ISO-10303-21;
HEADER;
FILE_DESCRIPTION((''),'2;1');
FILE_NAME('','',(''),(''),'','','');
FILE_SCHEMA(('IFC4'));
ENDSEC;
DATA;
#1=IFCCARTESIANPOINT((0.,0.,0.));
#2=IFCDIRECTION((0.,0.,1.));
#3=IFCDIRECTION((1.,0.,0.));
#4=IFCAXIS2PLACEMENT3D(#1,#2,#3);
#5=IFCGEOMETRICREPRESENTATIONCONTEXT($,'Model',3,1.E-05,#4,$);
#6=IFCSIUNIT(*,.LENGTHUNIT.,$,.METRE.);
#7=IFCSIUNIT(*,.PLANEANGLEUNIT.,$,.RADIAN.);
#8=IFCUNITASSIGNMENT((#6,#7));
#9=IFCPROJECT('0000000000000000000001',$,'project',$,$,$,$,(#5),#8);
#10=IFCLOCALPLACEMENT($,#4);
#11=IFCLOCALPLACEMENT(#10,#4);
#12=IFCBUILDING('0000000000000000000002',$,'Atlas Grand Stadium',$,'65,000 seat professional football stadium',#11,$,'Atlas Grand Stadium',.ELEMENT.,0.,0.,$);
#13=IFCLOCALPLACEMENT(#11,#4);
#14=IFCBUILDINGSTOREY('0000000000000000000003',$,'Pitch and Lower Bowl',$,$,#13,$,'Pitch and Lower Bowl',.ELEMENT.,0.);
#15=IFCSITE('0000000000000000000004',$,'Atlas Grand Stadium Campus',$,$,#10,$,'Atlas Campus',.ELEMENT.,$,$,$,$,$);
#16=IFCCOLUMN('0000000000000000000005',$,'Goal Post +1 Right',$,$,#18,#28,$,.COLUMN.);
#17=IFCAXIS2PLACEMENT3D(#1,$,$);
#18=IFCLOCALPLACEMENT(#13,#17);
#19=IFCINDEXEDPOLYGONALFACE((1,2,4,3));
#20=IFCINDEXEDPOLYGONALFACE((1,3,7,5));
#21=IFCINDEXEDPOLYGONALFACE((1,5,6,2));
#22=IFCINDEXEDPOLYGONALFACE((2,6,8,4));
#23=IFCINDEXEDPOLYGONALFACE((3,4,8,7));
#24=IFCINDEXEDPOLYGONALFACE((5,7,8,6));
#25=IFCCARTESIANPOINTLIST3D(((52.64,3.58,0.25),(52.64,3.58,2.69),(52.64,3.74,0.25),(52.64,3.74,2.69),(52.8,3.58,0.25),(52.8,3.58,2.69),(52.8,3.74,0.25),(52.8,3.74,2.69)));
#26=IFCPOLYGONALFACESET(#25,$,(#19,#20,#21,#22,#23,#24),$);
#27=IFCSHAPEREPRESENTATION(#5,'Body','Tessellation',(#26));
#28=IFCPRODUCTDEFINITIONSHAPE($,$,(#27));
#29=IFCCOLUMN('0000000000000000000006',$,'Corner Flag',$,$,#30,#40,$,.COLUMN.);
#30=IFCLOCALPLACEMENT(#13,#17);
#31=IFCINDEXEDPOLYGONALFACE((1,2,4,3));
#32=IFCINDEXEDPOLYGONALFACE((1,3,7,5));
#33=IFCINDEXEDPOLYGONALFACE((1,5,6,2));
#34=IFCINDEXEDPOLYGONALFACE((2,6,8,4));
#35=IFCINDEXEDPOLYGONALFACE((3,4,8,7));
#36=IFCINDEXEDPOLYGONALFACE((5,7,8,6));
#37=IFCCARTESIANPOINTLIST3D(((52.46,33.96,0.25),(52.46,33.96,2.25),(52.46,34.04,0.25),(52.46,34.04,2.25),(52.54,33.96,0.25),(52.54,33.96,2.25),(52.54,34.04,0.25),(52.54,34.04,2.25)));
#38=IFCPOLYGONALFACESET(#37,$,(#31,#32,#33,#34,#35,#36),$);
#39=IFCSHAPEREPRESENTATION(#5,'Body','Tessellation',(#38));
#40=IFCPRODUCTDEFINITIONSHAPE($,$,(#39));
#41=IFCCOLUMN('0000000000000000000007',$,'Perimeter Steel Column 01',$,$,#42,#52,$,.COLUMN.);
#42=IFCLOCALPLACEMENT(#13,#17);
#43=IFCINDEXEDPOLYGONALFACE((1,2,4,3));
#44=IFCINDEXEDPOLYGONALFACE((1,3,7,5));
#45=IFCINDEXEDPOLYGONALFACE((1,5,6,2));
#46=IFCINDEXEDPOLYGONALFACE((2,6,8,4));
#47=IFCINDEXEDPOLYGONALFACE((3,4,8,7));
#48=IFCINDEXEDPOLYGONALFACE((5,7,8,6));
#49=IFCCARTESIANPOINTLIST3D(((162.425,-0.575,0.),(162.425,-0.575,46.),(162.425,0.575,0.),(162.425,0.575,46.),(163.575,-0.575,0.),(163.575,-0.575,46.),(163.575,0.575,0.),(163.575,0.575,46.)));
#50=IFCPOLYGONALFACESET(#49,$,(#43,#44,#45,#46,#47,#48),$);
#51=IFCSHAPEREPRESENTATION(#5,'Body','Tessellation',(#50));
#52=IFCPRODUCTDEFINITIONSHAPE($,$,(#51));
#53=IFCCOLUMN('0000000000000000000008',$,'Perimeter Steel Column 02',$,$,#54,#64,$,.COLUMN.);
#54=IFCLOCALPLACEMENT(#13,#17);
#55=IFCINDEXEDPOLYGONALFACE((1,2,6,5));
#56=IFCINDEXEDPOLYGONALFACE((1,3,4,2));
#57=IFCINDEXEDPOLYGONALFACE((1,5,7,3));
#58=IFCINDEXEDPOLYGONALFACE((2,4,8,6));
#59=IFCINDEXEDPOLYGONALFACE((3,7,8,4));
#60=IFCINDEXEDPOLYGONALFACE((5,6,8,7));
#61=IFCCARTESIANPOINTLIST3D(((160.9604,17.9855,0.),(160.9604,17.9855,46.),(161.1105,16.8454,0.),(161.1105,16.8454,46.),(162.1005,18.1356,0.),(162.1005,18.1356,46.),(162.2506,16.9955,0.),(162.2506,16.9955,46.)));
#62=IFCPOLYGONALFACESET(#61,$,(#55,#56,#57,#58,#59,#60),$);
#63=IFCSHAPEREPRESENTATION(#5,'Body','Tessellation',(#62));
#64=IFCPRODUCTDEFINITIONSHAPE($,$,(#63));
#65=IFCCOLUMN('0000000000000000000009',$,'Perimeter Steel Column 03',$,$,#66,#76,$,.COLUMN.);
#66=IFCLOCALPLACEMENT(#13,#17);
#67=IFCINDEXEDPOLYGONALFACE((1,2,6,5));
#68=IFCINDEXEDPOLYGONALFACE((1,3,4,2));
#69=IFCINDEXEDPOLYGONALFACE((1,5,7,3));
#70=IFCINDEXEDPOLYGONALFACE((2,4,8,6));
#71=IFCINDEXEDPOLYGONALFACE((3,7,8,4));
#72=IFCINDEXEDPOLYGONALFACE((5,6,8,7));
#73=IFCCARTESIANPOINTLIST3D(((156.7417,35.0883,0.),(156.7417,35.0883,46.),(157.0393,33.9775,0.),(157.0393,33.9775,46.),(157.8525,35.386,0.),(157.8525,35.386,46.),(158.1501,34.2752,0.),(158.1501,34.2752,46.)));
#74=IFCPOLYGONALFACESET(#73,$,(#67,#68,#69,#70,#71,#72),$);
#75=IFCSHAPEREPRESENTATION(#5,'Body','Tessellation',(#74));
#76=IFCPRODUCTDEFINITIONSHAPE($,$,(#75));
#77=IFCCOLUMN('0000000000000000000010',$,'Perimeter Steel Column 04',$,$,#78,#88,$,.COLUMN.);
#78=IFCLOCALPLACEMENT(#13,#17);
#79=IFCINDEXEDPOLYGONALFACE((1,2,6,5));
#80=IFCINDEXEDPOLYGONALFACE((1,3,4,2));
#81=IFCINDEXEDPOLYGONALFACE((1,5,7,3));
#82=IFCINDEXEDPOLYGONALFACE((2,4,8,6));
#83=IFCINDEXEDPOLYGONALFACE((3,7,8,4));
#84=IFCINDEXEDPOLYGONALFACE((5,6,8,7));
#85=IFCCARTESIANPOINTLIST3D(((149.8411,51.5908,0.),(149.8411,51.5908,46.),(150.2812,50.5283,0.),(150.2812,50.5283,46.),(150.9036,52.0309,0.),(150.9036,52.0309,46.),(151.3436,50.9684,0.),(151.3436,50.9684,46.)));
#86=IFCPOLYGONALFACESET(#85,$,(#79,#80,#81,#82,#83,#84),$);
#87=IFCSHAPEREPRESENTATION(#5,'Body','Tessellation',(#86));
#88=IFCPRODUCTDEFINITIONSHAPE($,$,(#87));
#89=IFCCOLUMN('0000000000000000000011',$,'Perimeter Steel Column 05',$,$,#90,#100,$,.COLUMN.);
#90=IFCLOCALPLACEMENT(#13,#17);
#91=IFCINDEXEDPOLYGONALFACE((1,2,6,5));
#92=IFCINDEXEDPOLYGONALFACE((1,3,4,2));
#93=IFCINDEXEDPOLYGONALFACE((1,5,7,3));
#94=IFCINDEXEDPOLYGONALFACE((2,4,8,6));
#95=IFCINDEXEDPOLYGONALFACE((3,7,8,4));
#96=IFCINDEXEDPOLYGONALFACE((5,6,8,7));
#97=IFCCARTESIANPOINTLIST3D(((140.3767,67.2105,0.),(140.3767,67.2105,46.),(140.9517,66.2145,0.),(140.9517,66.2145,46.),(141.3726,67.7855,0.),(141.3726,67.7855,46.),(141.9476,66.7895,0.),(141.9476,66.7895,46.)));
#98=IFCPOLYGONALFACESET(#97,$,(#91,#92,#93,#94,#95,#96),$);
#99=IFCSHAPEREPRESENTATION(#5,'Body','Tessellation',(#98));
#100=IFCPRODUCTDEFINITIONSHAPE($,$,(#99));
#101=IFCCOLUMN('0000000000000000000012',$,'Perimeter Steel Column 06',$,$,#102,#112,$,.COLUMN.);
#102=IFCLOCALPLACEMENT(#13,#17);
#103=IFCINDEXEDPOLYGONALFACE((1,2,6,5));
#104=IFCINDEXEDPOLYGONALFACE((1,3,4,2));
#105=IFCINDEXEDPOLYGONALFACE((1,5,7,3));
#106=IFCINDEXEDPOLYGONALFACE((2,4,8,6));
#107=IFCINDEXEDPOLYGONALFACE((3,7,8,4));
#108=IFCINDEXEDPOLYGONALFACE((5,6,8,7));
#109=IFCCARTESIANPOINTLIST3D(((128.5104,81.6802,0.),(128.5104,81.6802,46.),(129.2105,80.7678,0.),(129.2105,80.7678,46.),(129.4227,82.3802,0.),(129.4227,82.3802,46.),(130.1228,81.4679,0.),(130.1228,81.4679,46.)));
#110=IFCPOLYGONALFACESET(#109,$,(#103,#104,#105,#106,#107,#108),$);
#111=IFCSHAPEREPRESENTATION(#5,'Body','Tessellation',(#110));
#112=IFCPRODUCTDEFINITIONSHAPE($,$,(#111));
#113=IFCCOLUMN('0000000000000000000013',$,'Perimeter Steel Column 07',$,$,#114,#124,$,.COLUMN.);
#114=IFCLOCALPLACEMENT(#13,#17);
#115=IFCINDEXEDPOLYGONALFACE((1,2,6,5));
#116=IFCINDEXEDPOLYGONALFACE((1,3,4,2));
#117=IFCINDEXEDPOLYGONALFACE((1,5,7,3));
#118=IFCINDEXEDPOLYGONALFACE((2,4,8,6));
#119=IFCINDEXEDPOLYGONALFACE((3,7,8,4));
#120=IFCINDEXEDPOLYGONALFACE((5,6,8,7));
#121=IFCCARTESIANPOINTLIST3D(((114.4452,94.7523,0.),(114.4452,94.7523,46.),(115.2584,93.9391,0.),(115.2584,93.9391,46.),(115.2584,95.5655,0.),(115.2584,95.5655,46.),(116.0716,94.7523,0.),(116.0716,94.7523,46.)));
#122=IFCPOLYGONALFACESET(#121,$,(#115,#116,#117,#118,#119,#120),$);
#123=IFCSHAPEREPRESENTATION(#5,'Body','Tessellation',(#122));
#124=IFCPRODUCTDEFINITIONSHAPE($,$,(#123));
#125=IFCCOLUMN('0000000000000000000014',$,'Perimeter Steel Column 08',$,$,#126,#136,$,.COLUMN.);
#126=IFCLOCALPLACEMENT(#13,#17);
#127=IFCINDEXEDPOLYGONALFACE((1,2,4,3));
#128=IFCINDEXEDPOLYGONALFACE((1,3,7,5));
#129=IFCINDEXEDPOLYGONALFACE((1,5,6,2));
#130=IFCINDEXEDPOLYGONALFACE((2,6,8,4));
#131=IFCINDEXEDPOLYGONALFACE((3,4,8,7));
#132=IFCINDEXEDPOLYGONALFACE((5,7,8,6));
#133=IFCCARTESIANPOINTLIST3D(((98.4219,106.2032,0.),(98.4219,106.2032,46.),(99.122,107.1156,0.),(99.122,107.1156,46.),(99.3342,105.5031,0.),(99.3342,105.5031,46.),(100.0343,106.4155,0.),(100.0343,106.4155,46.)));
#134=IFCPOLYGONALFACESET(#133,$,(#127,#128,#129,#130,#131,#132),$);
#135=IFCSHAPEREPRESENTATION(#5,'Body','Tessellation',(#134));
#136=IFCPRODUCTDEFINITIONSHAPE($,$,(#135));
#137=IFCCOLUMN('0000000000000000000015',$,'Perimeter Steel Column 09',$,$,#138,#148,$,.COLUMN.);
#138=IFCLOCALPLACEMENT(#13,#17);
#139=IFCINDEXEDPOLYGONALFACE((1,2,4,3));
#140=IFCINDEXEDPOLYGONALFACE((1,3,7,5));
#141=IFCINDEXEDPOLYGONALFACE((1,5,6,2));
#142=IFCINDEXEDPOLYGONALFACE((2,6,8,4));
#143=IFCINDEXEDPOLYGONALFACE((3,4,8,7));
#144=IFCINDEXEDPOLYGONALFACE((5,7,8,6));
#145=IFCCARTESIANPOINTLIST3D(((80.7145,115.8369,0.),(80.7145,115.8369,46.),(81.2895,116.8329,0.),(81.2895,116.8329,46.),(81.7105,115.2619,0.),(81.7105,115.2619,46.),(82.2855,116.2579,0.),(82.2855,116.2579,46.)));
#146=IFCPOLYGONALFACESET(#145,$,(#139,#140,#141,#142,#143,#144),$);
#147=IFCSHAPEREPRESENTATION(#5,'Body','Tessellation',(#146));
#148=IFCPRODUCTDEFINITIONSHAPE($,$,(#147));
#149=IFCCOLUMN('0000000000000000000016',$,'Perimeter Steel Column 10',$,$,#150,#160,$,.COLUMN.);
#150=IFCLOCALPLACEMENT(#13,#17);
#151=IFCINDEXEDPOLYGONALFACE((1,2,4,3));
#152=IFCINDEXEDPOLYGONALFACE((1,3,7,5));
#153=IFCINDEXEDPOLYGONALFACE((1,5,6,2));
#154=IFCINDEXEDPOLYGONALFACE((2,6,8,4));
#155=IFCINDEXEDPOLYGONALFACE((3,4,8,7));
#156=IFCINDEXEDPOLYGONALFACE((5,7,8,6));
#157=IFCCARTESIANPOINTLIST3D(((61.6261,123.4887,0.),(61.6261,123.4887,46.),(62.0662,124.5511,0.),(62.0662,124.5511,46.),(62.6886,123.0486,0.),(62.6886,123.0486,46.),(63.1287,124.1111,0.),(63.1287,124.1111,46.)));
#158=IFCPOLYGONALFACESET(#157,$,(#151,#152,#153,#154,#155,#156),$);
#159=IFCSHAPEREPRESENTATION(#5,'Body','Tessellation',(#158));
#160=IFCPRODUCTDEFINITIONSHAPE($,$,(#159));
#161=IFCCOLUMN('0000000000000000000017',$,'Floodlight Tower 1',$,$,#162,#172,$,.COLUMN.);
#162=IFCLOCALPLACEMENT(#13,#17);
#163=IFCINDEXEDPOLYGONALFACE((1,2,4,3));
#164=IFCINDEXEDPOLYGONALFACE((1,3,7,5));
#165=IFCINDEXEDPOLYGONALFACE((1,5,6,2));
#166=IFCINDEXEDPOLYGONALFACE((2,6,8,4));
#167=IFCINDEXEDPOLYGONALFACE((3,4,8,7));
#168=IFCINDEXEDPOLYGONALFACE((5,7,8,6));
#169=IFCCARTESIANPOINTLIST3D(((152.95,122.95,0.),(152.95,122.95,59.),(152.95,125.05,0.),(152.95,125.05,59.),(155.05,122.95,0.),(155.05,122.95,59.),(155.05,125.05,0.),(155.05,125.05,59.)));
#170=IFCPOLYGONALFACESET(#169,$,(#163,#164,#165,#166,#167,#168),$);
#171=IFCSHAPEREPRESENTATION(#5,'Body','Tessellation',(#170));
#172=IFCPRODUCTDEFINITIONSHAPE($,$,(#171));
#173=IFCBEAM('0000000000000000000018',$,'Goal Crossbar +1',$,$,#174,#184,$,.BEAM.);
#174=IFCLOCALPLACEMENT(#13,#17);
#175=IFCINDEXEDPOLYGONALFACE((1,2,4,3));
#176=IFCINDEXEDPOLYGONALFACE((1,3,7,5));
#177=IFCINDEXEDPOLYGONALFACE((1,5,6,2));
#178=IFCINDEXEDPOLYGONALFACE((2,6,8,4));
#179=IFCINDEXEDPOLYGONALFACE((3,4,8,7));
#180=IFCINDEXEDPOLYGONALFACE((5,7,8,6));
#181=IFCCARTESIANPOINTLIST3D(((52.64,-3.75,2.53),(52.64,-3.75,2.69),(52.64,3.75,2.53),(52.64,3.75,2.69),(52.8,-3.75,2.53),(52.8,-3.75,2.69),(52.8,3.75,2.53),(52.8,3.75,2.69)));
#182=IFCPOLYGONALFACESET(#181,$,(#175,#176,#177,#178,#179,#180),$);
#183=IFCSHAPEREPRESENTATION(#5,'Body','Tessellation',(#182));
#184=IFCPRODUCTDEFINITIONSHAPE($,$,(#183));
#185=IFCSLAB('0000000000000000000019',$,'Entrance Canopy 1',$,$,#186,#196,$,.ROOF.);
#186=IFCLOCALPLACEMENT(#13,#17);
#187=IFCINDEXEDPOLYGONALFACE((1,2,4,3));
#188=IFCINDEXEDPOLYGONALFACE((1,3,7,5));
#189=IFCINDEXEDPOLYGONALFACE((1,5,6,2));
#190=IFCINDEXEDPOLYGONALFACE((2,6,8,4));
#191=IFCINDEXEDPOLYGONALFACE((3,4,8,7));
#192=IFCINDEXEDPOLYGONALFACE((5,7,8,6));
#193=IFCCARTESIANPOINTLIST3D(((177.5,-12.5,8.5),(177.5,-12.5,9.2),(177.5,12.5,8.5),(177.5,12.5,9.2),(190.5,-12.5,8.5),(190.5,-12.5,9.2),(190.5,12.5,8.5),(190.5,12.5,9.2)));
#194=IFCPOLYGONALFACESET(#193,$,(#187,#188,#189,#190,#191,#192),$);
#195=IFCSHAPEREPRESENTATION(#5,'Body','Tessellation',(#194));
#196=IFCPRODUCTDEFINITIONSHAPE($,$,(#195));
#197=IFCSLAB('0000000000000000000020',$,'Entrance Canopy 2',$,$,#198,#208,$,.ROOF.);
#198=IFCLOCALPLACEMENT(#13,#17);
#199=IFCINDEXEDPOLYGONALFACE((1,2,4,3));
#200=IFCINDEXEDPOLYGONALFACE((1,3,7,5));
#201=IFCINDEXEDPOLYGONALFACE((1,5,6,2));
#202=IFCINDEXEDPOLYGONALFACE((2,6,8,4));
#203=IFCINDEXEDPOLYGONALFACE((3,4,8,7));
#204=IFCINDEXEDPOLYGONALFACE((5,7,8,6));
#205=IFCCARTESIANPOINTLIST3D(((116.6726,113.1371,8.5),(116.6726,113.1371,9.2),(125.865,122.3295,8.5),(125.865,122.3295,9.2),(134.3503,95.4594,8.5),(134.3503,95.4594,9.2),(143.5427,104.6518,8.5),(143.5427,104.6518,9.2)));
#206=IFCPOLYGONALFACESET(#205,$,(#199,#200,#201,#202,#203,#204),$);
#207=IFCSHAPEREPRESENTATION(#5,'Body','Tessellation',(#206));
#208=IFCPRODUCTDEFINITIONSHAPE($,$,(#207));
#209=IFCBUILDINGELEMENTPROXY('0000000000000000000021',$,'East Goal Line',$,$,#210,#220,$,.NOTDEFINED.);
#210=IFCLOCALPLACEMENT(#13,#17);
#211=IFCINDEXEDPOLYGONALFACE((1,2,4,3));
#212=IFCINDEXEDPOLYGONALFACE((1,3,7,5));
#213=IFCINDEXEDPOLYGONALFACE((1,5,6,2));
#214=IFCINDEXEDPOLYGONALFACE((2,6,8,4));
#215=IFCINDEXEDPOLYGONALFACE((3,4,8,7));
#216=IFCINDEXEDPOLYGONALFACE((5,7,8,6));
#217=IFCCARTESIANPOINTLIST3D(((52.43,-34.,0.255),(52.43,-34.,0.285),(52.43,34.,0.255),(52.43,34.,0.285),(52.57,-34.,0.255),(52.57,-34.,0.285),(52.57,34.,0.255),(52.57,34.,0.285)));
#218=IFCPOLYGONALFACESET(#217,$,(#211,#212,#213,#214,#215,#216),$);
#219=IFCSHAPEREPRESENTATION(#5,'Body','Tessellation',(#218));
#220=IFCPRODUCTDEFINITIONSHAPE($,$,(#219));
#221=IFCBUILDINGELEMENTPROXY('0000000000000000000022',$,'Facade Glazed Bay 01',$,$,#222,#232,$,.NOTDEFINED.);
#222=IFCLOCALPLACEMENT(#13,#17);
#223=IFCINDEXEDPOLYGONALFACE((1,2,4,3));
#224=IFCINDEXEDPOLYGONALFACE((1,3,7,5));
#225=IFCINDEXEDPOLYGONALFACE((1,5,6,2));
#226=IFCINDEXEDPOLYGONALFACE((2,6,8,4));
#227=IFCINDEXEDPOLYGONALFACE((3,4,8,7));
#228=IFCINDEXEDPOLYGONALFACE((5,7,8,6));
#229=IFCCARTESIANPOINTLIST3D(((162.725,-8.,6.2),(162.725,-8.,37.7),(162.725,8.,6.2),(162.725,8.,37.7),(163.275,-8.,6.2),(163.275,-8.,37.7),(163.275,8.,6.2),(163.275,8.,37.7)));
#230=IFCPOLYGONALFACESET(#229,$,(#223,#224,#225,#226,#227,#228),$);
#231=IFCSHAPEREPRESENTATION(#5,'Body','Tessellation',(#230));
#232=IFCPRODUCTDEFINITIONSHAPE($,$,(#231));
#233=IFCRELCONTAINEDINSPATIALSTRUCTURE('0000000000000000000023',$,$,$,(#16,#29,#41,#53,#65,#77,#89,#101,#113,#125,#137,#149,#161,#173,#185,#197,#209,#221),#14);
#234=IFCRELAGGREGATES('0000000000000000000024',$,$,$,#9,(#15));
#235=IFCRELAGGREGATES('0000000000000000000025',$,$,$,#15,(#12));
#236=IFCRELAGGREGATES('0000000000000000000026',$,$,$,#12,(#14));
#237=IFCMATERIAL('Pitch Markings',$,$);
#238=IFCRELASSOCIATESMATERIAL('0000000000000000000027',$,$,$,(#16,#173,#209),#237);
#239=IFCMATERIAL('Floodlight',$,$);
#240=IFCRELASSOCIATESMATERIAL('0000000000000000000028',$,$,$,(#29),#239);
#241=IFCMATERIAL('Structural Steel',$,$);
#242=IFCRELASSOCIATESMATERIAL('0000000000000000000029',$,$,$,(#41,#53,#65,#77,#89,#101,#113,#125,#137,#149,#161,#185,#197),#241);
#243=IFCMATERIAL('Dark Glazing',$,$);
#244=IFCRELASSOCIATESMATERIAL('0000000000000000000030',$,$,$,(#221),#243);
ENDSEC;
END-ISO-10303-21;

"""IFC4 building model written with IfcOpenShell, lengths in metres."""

from ifc_helpers import new_model, si_unit, frame, origin_with_axes, origin_2d_with_axis, place, context, project, spatial, rectangle, extrude, material, element, save


model = new_model("IFC4")

# Units and contexts
model_context = context("Model", 3, precision=1e-05, world=origin_with_axes())
ifc_project = project(units=[si_unit("LENGTHUNIT", "METRE"), si_unit("PLANEANGLEUNIT", "RADIAN")], contexts=[model_context])

# Site, building, storey
site_placement = place(None, origin_with_axes())
site = spatial("IfcSite", under=ifc_project, at=site_placement, Name="Atlas Grand Stadium Campus", LongName="Atlas Campus", CompositionType="ELEMENT")
building_placement = place(site_placement, origin_with_axes())
building = spatial("IfcBuilding", under=site, at=building_placement, Name="Atlas Grand Stadium", ObjectType="65,000 seat professional football stadium", LongName="Atlas Grand Stadium", CompositionType="ELEMENT", ElevationOfRefHeight=0.0, ElevationOfTerrain=0.0)
storey_placement = place(building_placement, origin_with_axes())
storey = spatial("IfcBuildingStorey", under=building, at=storey_placement, Name="Pitch and Lower Bowl", LongName="Pitch and Lower Bowl", CompositionType="ELEMENT", Elevation=0.0)

# Columns
ifc_material_1 = material(Name="Pitch Markings")
column_1_placement = place(storey_placement, frame((52.72, 3.66, 0.25), z_axis=(0.0, 0.0, 1.0), x_axis=(1.0, 0.0, 0.0)))
element("IfcColumn", 1, at=column_1_placement, inside=storey, material=ifc_material_1, Name="Goal Post +1 Right", PredefinedType="COLUMN", context=model_context, shape_type="SweptSolid", body=[
    extrude(rectangle(XDim=0.16, YDim=0.16, at=origin_2d_with_axis()), origin_with_axes(), (0.0, 0.0, 1.0), 2.44),
])
ifc_material_2 = material(Name="Floodlight")
column_2_placement = place(storey_placement, frame((52.5, 34.0, 0.25), z_axis=(0.0, 0.0, 1.0), x_axis=(1.0, 0.0, 0.0)))
element("IfcColumn", 2, at=column_2_placement, inside=storey, material=ifc_material_2, Name="Corner Flag", PredefinedType="COLUMN", context=model_context, shape_type="SweptSolid", body=[
    extrude(rectangle(XDim=0.08, YDim=0.08, at=origin_2d_with_axis()), origin_with_axes(), (0.0, 0.0, 1.0), 2.0),
])
ifc_material_3 = material(Name="Structural Steel")
for number, where, z_axis, x_axis, name in (
    (3, (163.0, 0.0, 0.0), (0.0, 0.0, 1.0), (0.0, 1.0, 0.0), "Perimeter Steel Column 01"),
    (4, (161.6055, 17.4905, 0.0), (0.0, 0.0, 1.0), (-0.13053, 0.99144, 0.0), "Perimeter Steel Column 02"),
    (5, (157.4459, 34.6818, 0.0), (0.0, 0.0, 1.0), (-0.25882, 0.96593, 0.0), "Perimeter Steel Column 03"),
    (6, (150.5924, 51.2796, 0.0), (0.0, 0.0, 1.0), (-0.38268, 0.92388, 0.0), "Perimeter Steel Column 04"),
    (7, (141.1621, 67.0, 0.0), (0.0, 0.0, 1.0), (-0.5, 0.86603, 0.0), "Perimeter Steel Column 05"),
    (8, (129.3166, 81.574, 0.0), (0.0, 0.0, 1.0), (-0.60876, 0.79335, 0.0), "Perimeter Steel Column 06"),
    (9, (115.2584, 94.7523, 0.0), (0.0, 0.0, 1.0), (-0.70711, 0.70711, 0.0), "Perimeter Steel Column 07"),
    (10, (99.2281, 106.3093, 0.0), (0.0, 0.0, 1.0), (-0.79335, 0.60876, 0.0), "Perimeter Steel Column 08"),
    (11, (81.5, 116.0474, 0.0), (0.0, 0.0, 1.0), (-0.86603, 0.5, 0.0), "Perimeter Steel Column 09"),
    (12, (62.3774, 123.7999, 0.0), (0.0, 0.0, 1.0), (-0.92388, 0.38268, 0.0), "Perimeter Steel Column 10"),
):
    element("IfcColumn", number, at=place(storey_placement, frame(where, z_axis=z_axis, x_axis=x_axis)), inside=storey, material=ifc_material_3, Name=name, PredefinedType="COLUMN", context=model_context, shape_type="SweptSolid", body=[
        extrude(rectangle(XDim=1.15, YDim=1.15, at=origin_2d_with_axis()), origin_with_axes(), (0.0, 0.0, 1.0), 46.0),
    ])
column_3_placement = place(storey_placement, frame((154.0, 124.0, 0.0), z_axis=(0.0, 0.0, 1.0), x_axis=(1.0, 0.0, 0.0)))
element("IfcColumn", 13, at=column_3_placement, inside=storey, material=ifc_material_3, Name="Floodlight Tower 1", PredefinedType="COLUMN", context=model_context, shape_type="SweptSolid", body=[
    extrude(rectangle(XDim=2.1, YDim=2.1, at=origin_2d_with_axis()), origin_with_axes(), (0.0, 0.0, 1.0), 59.0),
])

# Beam
beam_placement = place(storey_placement, frame((52.72, 0.0, 2.53), z_axis=(0.0, 0.0, 1.0), x_axis=(1.0, 0.0, 0.0)))
element("IfcBeam", 14, at=beam_placement, inside=storey, material=ifc_material_1, Name="Goal Crossbar +1", PredefinedType="BEAM", context=model_context, shape_type="SweptSolid", body=[
    extrude(rectangle(XDim=0.16, YDim=7.5, at=origin_2d_with_axis()), origin_with_axes(), (0.0, 0.0, 1.0), 0.16),
])

# Slabs
for number, where, z_axis, x_axis, name in (
    (15, (184.0, 0.0, 8.5), (0.0, 0.0, 1.0), (0.0, 1.0, 0.0), "Entrance Canopy 1"),
    (16, (130.1077, 108.8944, 8.5), (0.0, 0.0, 1.0), (-0.70711, 0.70711, 0.0), "Entrance Canopy 2"),
):
    element("IfcSlab", number, at=place(storey_placement, frame(where, z_axis=z_axis, x_axis=x_axis)), inside=storey, material=ifc_material_3, Name=name, PredefinedType="ROOF", context=model_context, shape_type="SweptSolid", body=[
        extrude(rectangle(XDim=25.0, YDim=13.0, at=origin_2d_with_axis()), origin_with_axes(), (0.0, 0.0, 1.0), 0.7),
    ])

# Building element proxies
proxy_placement = place(storey_placement, frame((52.5, 0.0, 0.255), z_axis=(0.0, 0.0, 1.0), x_axis=(1.0, 0.0, 0.0)))
element("IfcBuildingElementProxy", 17, at=proxy_placement, inside=storey, material=ifc_material_1, Name="East Goal Line", PredefinedType="NOTDEFINED", context=model_context, shape_type="SweptSolid", body=[
    extrude(rectangle(XDim=0.14, YDim=68.0, at=origin_2d_with_axis()), origin_with_axes(), (0.0, 0.0, 1.0), 0.03),
])
ifc_material_4 = material(Name="Dark Glazing")
for number, where, z_axis, x_axis, name in (
    (18, (163.0, 0.0, 6.2), (0.0, 0.0, 1.0), (0.0, 1.0, 0.0), "Facade Glazed Bay 01"),
):
    element("IfcBuildingElementProxy", number, at=place(storey_placement, frame(where, z_axis=z_axis, x_axis=x_axis)), inside=storey, material=ifc_material_4, Name=name, PredefinedType="NOTDEFINED", context=model_context, shape_type="SweptSolid", body=[
        extrude(rectangle(XDim=16.0, YDim=0.55, at=origin_2d_with_axis()), origin_with_axes(), (0.0, 0.0, 1.0), 31.5),
    ])

save(model, "model.ifc")
